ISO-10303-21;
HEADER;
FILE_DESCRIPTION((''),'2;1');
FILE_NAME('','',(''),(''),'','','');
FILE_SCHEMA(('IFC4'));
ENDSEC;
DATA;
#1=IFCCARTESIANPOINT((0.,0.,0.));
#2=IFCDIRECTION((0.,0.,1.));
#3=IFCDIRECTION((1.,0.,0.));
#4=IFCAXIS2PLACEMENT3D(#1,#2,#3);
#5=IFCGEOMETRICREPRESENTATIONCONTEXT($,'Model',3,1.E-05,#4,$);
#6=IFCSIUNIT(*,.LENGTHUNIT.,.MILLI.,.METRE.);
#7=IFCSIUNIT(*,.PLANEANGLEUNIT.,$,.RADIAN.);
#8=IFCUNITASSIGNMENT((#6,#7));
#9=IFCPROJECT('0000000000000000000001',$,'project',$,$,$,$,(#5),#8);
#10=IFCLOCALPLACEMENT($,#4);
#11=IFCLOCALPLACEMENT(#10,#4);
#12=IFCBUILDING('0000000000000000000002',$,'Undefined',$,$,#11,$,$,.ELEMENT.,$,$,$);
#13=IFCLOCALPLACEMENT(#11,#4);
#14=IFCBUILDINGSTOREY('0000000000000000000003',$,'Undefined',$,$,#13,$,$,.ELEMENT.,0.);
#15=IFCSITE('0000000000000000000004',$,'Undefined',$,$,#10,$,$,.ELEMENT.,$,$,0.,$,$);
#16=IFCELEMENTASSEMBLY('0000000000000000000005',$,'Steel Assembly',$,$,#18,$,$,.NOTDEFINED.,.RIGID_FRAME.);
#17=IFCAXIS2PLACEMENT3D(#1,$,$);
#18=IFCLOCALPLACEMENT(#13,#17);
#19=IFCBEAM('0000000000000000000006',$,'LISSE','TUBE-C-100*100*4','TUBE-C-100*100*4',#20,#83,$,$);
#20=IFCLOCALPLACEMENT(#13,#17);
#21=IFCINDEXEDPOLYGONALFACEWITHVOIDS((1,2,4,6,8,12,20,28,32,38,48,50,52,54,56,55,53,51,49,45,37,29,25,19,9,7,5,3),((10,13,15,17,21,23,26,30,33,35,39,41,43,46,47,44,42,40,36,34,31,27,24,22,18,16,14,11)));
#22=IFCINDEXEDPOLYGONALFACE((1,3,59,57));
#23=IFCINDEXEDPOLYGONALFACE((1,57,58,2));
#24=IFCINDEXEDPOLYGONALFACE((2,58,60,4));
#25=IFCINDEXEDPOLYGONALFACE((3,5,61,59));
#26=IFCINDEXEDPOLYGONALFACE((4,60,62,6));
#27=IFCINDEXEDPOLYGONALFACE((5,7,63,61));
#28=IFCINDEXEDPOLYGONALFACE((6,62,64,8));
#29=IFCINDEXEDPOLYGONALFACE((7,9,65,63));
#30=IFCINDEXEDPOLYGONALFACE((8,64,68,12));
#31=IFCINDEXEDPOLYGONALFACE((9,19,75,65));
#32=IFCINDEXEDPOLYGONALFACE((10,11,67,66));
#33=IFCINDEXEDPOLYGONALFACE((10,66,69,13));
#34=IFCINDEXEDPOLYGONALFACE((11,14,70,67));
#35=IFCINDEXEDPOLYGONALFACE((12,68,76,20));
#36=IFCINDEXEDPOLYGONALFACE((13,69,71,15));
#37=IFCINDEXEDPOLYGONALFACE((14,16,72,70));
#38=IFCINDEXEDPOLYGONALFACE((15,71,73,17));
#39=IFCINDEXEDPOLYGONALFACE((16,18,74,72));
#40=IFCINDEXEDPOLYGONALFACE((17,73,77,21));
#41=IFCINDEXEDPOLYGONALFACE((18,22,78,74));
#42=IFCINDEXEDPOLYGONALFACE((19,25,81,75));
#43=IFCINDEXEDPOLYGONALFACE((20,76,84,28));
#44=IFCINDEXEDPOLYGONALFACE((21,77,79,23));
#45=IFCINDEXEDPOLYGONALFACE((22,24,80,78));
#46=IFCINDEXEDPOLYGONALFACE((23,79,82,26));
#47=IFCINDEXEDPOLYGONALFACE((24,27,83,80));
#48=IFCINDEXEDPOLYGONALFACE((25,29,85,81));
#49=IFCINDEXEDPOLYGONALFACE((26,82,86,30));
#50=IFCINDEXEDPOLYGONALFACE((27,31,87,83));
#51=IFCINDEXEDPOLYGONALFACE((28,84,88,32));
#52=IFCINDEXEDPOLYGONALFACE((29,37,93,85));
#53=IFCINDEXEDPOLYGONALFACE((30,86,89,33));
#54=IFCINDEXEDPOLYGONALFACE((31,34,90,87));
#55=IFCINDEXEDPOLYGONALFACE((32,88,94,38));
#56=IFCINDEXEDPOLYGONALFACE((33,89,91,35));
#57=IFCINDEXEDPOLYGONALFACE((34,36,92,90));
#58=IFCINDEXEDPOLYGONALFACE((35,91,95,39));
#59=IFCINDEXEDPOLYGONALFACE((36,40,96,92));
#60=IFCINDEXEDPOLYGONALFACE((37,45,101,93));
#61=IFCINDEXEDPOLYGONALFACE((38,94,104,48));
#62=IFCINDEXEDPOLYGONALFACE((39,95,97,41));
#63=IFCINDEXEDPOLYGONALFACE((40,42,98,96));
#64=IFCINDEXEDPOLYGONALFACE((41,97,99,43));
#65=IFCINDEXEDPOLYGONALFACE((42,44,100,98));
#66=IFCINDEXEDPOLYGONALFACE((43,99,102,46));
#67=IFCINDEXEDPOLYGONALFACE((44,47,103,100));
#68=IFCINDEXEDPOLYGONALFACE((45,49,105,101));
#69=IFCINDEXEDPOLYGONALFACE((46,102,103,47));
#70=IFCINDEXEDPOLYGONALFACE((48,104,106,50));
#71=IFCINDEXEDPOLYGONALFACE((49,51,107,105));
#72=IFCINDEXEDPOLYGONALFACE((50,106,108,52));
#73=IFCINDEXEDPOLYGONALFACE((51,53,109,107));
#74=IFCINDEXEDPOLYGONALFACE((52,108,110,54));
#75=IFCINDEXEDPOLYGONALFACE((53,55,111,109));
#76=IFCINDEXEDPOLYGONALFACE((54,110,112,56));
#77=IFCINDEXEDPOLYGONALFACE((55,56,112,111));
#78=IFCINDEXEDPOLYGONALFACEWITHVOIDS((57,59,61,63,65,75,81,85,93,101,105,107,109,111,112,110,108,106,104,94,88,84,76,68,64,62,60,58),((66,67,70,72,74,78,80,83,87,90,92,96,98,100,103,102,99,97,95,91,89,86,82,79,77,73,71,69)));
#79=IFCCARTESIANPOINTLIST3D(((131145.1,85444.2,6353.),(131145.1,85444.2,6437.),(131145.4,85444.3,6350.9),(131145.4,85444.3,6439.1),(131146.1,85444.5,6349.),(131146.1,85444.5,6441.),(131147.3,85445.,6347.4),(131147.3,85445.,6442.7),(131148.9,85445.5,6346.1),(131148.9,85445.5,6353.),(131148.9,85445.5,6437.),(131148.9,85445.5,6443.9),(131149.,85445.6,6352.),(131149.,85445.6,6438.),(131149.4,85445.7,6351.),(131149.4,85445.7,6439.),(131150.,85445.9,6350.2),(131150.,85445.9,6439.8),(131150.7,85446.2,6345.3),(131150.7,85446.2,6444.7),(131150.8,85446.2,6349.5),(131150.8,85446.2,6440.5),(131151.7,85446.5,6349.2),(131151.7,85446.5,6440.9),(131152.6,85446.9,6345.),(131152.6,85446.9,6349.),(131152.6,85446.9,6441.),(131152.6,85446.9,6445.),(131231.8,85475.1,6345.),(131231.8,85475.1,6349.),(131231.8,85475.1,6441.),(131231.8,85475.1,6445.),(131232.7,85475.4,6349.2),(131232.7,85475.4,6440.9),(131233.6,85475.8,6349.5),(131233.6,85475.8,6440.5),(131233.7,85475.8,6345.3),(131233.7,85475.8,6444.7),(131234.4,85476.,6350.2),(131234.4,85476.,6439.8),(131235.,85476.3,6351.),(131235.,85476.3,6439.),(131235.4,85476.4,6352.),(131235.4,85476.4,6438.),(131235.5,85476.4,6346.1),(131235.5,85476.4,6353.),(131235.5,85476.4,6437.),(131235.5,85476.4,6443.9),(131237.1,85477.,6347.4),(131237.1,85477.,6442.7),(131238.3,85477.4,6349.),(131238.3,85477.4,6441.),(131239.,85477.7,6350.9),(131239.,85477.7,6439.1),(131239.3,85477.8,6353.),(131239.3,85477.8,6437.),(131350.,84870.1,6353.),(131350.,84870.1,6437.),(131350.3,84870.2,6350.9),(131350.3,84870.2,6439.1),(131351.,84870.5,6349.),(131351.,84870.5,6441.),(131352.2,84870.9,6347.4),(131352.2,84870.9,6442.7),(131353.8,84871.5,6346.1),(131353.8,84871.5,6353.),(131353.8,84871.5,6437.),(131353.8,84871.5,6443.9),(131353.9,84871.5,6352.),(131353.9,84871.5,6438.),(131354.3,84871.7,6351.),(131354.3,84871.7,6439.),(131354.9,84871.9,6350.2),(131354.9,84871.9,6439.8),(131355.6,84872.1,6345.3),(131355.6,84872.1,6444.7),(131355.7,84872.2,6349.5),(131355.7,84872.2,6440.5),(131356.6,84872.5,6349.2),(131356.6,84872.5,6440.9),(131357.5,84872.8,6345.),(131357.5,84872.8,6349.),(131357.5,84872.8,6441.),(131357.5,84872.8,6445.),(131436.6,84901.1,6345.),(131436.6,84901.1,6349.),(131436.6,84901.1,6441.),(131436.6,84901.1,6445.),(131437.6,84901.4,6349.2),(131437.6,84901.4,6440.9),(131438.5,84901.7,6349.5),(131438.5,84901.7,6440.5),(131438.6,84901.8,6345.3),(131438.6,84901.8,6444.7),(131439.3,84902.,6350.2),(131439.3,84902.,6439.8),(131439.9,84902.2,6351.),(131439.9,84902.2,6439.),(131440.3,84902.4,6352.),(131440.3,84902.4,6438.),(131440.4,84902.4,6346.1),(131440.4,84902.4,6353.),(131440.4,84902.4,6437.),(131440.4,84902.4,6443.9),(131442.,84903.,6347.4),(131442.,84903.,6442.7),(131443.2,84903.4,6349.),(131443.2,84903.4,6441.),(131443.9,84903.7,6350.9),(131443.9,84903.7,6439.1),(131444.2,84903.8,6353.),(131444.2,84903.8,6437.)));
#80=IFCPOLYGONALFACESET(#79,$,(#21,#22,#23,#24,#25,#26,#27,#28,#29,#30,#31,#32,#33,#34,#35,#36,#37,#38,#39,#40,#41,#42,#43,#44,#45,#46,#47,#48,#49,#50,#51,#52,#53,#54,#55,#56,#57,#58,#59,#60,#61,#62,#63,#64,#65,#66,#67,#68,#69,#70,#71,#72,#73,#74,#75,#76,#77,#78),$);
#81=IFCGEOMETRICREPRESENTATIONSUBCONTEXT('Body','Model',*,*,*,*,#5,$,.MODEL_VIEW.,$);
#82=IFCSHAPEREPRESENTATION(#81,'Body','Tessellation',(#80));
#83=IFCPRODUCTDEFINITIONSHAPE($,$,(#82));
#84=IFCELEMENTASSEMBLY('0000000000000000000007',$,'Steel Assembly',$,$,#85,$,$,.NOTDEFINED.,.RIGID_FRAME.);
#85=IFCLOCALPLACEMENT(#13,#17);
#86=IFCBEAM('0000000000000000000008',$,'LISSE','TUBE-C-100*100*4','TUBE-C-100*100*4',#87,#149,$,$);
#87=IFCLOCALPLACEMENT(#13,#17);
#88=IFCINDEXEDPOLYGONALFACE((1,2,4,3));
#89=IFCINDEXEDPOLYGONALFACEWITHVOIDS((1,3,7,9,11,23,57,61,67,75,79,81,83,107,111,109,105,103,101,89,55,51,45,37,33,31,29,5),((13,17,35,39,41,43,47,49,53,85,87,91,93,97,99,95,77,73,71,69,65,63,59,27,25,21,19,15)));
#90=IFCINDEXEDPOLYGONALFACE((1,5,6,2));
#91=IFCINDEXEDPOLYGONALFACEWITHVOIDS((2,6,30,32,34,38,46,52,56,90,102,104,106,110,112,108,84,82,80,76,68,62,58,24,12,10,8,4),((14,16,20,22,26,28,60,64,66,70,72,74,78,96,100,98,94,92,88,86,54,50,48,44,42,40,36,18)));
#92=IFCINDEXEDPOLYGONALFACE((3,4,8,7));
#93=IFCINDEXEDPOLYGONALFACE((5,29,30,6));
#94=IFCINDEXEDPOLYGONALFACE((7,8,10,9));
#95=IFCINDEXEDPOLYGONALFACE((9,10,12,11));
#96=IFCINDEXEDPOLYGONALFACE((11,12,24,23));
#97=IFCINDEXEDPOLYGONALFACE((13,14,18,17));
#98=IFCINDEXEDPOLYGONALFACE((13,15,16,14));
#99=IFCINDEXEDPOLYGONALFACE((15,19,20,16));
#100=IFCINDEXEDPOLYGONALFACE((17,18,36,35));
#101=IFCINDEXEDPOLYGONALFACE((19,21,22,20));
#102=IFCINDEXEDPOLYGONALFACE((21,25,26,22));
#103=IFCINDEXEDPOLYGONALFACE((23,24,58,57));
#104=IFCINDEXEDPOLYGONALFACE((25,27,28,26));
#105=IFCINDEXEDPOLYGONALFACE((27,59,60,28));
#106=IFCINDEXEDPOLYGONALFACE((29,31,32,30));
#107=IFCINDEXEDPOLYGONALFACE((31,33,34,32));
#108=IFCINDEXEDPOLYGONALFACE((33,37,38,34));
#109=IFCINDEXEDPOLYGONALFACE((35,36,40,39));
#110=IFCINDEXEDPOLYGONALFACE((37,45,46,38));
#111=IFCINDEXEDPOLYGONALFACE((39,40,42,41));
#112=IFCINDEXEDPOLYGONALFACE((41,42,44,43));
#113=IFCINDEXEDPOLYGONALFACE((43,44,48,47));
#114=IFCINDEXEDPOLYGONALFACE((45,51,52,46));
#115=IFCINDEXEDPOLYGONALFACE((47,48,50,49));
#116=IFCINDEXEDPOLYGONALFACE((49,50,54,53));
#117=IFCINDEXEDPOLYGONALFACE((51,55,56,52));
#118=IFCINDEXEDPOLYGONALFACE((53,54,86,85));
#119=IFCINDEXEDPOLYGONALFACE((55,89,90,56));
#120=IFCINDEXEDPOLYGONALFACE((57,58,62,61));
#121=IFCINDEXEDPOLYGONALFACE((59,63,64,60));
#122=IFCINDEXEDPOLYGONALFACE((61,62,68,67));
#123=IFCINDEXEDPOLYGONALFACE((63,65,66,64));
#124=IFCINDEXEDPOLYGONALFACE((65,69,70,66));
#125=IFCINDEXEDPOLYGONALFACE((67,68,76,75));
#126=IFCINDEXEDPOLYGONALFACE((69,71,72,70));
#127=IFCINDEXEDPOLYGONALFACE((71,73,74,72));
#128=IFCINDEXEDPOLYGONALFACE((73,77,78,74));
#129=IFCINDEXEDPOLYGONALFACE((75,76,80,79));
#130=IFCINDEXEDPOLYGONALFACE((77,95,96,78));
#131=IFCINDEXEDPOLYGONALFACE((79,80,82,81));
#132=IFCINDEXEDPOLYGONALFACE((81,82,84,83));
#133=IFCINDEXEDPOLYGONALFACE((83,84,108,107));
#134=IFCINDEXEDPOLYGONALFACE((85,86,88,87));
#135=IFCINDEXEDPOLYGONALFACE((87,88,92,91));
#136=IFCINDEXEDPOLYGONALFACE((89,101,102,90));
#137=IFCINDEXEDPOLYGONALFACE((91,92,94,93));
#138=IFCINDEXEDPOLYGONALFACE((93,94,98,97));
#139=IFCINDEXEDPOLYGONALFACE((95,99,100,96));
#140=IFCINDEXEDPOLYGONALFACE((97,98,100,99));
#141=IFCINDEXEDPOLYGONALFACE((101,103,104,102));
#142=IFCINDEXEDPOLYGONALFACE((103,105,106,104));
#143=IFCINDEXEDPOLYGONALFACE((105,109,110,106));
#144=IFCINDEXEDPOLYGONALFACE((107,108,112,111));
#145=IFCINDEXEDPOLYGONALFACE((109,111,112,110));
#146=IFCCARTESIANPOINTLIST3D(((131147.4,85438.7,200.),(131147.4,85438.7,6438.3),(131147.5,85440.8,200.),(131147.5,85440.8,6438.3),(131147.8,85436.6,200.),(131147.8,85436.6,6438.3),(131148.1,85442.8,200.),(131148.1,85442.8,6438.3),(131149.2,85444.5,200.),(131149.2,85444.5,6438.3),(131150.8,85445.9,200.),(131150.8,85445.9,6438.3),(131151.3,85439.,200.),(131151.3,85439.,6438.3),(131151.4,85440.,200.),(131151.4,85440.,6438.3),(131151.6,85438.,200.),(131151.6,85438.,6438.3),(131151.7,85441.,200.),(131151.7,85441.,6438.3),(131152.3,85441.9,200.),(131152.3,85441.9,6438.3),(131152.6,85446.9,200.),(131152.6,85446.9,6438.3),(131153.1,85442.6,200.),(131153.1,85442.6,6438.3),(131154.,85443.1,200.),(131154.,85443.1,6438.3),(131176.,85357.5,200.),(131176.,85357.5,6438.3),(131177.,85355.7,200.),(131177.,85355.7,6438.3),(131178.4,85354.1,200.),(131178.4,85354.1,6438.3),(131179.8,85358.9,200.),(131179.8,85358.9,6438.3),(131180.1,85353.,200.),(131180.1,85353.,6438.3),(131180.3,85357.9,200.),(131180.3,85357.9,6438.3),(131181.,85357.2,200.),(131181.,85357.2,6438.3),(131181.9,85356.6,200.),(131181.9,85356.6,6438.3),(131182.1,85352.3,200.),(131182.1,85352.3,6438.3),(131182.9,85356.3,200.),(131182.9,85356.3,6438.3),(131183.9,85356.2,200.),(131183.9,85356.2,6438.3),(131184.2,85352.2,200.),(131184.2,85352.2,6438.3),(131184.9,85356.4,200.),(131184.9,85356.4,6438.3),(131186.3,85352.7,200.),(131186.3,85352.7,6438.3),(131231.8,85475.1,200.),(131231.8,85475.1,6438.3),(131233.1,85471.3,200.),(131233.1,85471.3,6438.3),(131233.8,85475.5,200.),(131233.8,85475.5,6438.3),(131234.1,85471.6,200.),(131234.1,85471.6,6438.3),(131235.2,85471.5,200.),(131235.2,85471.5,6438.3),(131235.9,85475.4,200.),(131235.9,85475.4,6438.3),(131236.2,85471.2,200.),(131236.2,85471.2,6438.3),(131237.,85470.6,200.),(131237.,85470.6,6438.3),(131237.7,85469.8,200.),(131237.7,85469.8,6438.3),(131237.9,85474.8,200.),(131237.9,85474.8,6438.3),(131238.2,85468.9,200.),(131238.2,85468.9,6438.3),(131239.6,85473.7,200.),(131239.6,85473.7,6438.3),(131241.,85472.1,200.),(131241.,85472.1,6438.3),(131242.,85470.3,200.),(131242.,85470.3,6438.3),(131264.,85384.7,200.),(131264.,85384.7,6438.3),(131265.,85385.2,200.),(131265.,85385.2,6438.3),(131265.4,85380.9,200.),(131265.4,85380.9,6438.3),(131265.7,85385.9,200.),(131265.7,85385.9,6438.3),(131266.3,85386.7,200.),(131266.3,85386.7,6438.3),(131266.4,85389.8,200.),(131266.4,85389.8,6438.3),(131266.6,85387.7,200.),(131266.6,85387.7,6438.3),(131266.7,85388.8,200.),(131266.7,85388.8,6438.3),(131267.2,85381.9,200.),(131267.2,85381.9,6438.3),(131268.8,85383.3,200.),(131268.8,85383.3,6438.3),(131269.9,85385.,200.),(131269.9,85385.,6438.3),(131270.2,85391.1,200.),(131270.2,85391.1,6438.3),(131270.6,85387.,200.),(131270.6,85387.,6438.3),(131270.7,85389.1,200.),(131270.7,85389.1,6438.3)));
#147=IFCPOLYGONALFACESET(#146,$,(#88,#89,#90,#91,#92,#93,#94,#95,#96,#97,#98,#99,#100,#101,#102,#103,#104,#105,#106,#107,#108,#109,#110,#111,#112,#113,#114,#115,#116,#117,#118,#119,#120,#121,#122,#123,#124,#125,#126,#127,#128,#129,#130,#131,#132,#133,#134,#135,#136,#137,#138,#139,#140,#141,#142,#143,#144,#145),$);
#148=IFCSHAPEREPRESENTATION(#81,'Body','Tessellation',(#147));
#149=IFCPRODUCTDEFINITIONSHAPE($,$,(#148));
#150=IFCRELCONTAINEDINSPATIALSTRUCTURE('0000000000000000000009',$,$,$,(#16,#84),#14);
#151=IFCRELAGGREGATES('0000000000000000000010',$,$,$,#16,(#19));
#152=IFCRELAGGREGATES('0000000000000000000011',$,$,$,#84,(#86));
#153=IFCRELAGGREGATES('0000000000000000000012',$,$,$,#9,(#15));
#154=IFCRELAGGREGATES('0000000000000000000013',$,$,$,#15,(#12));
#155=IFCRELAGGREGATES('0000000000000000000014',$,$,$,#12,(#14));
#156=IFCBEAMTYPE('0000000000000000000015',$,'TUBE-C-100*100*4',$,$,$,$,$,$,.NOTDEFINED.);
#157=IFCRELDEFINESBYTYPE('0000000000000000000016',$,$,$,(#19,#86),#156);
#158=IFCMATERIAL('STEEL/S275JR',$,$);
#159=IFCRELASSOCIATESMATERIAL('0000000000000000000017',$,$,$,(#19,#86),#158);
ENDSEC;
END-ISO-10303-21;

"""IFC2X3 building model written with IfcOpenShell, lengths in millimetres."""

from ifc_helpers import new_model, si_unit, frame, origin_with_axes, origin_2d_with_axis, place, context, subcontext, project, spatial, hollow_rectangle, extrude, material, type_object, element, aggregate, save


model = new_model("IFC2X3")

# Units and contexts
model_context = context("Model", 3, precision=1e-05, world=origin_with_axes())
body_context = subcontext(model_context, "Body", "Model", "MODEL_VIEW")
ifc_project = project(units=[si_unit("LENGTHUNIT", "METRE", prefix="MILLI"), si_unit("PLANEANGLEUNIT", "RADIAN")], contexts=[model_context])

# Site, building, storey
site_placement = place(None, origin_with_axes())
site = spatial("IfcSite", under=ifc_project, at=site_placement, Name="Undefined", CompositionType="ELEMENT", RefElevation=0.0)
building_placement = place(site_placement, origin_with_axes())
building = spatial("IfcBuilding", under=site, at=building_placement, Name="Undefined", CompositionType="ELEMENT")
storey_placement = place(building_placement, origin_with_axes())
storey = spatial("IfcBuildingStorey", under=building, at=storey_placement, Name="Undefined", CompositionType="ELEMENT", Elevation=0.0)

# Shared definitions
ifc_material = material(Name="STEEL/S275JR")

# Element assemblies, beams
beam_type_1 = type_object("IfcBeamType", Name="TUBE-C-100*100*4", PredefinedType="NOTDEFINED")
assembly_1_placement = place(storey_placement, origin_with_axes())
assembly_1 = element("IfcElementAssembly", 1, at=assembly_1_placement, inside=storey, Name="Steel Assembly", AssemblyPlace="NOTDEFINED", PredefinedType="RIGID_FRAME")
beam_1_placement = place(assembly_1_placement, frame((131397.1, 84887.0, 6395.0), z_axis=(0.941802, 0.336169, 0.0), x_axis=(-0.336169, 0.941802, 0.0)))
beam_1 = element("IfcBeam", 2, at=beam_1_placement, type_object=beam_type_1, material=ifc_material, Name="LISSE", Description="TUBE-C-100*100*4", ObjectType="TUBE-C-100*100*4", context=body_context, shape_type="SweptSolid", body=[
    extrude(hollow_rectangle(XDim=100.0, YDim=100.0, WallThickness=4.0, InnerFilletRadius=4.0, OuterFilletRadius=8.0, at=origin_2d_with_axis()), frame((609.5, 0.0, 0.0), z_axis=(-1.0, 0.0, 0.0), x_axis=(0.0, -1.0, 0.0)), (0.0, 0.0, 1.0), 609.5),
])
aggregate(assembly_1, [beam_1])
assembly_2_placement = place(storey_placement, origin_with_axes())
assembly_2 = element("IfcElementAssembly", 3, at=assembly_2_placement, inside=storey, Name="Steel Assembly", AssemblyPlace="NOTDEFINED", PredefinedType="RIGID_FRAME")
beam_2_placement = place(assembly_2_placement, frame((131209.0, 85413.9, 6438.3), z_axis=(0.941802, 0.336168, 0.0), x_axis=(0.0, 0.0, -1.0)))
beam_2 = element("IfcBeam", 4, at=beam_2_placement, type_object=beam_type_1, material=ifc_material, Name="LISSE", Description="TUBE-C-100*100*4", ObjectType="TUBE-C-100*100*4", context=body_context, shape_type="SweptSolid", body=[
    extrude(hollow_rectangle(XDim=100.0, YDim=100.0, WallThickness=4.0, InnerFilletRadius=4.0, OuterFilletRadius=8.0, at=origin_2d_with_axis()), frame((6238.3, 0.0, 0.0), z_axis=(-1.0, 0.0, 0.0), x_axis=(0.0, -1.0, 0.0)), (0.0, 0.0, 1.0), 6238.3),
])
aggregate(assembly_2, [beam_2])

save(model, "model.ifc")
